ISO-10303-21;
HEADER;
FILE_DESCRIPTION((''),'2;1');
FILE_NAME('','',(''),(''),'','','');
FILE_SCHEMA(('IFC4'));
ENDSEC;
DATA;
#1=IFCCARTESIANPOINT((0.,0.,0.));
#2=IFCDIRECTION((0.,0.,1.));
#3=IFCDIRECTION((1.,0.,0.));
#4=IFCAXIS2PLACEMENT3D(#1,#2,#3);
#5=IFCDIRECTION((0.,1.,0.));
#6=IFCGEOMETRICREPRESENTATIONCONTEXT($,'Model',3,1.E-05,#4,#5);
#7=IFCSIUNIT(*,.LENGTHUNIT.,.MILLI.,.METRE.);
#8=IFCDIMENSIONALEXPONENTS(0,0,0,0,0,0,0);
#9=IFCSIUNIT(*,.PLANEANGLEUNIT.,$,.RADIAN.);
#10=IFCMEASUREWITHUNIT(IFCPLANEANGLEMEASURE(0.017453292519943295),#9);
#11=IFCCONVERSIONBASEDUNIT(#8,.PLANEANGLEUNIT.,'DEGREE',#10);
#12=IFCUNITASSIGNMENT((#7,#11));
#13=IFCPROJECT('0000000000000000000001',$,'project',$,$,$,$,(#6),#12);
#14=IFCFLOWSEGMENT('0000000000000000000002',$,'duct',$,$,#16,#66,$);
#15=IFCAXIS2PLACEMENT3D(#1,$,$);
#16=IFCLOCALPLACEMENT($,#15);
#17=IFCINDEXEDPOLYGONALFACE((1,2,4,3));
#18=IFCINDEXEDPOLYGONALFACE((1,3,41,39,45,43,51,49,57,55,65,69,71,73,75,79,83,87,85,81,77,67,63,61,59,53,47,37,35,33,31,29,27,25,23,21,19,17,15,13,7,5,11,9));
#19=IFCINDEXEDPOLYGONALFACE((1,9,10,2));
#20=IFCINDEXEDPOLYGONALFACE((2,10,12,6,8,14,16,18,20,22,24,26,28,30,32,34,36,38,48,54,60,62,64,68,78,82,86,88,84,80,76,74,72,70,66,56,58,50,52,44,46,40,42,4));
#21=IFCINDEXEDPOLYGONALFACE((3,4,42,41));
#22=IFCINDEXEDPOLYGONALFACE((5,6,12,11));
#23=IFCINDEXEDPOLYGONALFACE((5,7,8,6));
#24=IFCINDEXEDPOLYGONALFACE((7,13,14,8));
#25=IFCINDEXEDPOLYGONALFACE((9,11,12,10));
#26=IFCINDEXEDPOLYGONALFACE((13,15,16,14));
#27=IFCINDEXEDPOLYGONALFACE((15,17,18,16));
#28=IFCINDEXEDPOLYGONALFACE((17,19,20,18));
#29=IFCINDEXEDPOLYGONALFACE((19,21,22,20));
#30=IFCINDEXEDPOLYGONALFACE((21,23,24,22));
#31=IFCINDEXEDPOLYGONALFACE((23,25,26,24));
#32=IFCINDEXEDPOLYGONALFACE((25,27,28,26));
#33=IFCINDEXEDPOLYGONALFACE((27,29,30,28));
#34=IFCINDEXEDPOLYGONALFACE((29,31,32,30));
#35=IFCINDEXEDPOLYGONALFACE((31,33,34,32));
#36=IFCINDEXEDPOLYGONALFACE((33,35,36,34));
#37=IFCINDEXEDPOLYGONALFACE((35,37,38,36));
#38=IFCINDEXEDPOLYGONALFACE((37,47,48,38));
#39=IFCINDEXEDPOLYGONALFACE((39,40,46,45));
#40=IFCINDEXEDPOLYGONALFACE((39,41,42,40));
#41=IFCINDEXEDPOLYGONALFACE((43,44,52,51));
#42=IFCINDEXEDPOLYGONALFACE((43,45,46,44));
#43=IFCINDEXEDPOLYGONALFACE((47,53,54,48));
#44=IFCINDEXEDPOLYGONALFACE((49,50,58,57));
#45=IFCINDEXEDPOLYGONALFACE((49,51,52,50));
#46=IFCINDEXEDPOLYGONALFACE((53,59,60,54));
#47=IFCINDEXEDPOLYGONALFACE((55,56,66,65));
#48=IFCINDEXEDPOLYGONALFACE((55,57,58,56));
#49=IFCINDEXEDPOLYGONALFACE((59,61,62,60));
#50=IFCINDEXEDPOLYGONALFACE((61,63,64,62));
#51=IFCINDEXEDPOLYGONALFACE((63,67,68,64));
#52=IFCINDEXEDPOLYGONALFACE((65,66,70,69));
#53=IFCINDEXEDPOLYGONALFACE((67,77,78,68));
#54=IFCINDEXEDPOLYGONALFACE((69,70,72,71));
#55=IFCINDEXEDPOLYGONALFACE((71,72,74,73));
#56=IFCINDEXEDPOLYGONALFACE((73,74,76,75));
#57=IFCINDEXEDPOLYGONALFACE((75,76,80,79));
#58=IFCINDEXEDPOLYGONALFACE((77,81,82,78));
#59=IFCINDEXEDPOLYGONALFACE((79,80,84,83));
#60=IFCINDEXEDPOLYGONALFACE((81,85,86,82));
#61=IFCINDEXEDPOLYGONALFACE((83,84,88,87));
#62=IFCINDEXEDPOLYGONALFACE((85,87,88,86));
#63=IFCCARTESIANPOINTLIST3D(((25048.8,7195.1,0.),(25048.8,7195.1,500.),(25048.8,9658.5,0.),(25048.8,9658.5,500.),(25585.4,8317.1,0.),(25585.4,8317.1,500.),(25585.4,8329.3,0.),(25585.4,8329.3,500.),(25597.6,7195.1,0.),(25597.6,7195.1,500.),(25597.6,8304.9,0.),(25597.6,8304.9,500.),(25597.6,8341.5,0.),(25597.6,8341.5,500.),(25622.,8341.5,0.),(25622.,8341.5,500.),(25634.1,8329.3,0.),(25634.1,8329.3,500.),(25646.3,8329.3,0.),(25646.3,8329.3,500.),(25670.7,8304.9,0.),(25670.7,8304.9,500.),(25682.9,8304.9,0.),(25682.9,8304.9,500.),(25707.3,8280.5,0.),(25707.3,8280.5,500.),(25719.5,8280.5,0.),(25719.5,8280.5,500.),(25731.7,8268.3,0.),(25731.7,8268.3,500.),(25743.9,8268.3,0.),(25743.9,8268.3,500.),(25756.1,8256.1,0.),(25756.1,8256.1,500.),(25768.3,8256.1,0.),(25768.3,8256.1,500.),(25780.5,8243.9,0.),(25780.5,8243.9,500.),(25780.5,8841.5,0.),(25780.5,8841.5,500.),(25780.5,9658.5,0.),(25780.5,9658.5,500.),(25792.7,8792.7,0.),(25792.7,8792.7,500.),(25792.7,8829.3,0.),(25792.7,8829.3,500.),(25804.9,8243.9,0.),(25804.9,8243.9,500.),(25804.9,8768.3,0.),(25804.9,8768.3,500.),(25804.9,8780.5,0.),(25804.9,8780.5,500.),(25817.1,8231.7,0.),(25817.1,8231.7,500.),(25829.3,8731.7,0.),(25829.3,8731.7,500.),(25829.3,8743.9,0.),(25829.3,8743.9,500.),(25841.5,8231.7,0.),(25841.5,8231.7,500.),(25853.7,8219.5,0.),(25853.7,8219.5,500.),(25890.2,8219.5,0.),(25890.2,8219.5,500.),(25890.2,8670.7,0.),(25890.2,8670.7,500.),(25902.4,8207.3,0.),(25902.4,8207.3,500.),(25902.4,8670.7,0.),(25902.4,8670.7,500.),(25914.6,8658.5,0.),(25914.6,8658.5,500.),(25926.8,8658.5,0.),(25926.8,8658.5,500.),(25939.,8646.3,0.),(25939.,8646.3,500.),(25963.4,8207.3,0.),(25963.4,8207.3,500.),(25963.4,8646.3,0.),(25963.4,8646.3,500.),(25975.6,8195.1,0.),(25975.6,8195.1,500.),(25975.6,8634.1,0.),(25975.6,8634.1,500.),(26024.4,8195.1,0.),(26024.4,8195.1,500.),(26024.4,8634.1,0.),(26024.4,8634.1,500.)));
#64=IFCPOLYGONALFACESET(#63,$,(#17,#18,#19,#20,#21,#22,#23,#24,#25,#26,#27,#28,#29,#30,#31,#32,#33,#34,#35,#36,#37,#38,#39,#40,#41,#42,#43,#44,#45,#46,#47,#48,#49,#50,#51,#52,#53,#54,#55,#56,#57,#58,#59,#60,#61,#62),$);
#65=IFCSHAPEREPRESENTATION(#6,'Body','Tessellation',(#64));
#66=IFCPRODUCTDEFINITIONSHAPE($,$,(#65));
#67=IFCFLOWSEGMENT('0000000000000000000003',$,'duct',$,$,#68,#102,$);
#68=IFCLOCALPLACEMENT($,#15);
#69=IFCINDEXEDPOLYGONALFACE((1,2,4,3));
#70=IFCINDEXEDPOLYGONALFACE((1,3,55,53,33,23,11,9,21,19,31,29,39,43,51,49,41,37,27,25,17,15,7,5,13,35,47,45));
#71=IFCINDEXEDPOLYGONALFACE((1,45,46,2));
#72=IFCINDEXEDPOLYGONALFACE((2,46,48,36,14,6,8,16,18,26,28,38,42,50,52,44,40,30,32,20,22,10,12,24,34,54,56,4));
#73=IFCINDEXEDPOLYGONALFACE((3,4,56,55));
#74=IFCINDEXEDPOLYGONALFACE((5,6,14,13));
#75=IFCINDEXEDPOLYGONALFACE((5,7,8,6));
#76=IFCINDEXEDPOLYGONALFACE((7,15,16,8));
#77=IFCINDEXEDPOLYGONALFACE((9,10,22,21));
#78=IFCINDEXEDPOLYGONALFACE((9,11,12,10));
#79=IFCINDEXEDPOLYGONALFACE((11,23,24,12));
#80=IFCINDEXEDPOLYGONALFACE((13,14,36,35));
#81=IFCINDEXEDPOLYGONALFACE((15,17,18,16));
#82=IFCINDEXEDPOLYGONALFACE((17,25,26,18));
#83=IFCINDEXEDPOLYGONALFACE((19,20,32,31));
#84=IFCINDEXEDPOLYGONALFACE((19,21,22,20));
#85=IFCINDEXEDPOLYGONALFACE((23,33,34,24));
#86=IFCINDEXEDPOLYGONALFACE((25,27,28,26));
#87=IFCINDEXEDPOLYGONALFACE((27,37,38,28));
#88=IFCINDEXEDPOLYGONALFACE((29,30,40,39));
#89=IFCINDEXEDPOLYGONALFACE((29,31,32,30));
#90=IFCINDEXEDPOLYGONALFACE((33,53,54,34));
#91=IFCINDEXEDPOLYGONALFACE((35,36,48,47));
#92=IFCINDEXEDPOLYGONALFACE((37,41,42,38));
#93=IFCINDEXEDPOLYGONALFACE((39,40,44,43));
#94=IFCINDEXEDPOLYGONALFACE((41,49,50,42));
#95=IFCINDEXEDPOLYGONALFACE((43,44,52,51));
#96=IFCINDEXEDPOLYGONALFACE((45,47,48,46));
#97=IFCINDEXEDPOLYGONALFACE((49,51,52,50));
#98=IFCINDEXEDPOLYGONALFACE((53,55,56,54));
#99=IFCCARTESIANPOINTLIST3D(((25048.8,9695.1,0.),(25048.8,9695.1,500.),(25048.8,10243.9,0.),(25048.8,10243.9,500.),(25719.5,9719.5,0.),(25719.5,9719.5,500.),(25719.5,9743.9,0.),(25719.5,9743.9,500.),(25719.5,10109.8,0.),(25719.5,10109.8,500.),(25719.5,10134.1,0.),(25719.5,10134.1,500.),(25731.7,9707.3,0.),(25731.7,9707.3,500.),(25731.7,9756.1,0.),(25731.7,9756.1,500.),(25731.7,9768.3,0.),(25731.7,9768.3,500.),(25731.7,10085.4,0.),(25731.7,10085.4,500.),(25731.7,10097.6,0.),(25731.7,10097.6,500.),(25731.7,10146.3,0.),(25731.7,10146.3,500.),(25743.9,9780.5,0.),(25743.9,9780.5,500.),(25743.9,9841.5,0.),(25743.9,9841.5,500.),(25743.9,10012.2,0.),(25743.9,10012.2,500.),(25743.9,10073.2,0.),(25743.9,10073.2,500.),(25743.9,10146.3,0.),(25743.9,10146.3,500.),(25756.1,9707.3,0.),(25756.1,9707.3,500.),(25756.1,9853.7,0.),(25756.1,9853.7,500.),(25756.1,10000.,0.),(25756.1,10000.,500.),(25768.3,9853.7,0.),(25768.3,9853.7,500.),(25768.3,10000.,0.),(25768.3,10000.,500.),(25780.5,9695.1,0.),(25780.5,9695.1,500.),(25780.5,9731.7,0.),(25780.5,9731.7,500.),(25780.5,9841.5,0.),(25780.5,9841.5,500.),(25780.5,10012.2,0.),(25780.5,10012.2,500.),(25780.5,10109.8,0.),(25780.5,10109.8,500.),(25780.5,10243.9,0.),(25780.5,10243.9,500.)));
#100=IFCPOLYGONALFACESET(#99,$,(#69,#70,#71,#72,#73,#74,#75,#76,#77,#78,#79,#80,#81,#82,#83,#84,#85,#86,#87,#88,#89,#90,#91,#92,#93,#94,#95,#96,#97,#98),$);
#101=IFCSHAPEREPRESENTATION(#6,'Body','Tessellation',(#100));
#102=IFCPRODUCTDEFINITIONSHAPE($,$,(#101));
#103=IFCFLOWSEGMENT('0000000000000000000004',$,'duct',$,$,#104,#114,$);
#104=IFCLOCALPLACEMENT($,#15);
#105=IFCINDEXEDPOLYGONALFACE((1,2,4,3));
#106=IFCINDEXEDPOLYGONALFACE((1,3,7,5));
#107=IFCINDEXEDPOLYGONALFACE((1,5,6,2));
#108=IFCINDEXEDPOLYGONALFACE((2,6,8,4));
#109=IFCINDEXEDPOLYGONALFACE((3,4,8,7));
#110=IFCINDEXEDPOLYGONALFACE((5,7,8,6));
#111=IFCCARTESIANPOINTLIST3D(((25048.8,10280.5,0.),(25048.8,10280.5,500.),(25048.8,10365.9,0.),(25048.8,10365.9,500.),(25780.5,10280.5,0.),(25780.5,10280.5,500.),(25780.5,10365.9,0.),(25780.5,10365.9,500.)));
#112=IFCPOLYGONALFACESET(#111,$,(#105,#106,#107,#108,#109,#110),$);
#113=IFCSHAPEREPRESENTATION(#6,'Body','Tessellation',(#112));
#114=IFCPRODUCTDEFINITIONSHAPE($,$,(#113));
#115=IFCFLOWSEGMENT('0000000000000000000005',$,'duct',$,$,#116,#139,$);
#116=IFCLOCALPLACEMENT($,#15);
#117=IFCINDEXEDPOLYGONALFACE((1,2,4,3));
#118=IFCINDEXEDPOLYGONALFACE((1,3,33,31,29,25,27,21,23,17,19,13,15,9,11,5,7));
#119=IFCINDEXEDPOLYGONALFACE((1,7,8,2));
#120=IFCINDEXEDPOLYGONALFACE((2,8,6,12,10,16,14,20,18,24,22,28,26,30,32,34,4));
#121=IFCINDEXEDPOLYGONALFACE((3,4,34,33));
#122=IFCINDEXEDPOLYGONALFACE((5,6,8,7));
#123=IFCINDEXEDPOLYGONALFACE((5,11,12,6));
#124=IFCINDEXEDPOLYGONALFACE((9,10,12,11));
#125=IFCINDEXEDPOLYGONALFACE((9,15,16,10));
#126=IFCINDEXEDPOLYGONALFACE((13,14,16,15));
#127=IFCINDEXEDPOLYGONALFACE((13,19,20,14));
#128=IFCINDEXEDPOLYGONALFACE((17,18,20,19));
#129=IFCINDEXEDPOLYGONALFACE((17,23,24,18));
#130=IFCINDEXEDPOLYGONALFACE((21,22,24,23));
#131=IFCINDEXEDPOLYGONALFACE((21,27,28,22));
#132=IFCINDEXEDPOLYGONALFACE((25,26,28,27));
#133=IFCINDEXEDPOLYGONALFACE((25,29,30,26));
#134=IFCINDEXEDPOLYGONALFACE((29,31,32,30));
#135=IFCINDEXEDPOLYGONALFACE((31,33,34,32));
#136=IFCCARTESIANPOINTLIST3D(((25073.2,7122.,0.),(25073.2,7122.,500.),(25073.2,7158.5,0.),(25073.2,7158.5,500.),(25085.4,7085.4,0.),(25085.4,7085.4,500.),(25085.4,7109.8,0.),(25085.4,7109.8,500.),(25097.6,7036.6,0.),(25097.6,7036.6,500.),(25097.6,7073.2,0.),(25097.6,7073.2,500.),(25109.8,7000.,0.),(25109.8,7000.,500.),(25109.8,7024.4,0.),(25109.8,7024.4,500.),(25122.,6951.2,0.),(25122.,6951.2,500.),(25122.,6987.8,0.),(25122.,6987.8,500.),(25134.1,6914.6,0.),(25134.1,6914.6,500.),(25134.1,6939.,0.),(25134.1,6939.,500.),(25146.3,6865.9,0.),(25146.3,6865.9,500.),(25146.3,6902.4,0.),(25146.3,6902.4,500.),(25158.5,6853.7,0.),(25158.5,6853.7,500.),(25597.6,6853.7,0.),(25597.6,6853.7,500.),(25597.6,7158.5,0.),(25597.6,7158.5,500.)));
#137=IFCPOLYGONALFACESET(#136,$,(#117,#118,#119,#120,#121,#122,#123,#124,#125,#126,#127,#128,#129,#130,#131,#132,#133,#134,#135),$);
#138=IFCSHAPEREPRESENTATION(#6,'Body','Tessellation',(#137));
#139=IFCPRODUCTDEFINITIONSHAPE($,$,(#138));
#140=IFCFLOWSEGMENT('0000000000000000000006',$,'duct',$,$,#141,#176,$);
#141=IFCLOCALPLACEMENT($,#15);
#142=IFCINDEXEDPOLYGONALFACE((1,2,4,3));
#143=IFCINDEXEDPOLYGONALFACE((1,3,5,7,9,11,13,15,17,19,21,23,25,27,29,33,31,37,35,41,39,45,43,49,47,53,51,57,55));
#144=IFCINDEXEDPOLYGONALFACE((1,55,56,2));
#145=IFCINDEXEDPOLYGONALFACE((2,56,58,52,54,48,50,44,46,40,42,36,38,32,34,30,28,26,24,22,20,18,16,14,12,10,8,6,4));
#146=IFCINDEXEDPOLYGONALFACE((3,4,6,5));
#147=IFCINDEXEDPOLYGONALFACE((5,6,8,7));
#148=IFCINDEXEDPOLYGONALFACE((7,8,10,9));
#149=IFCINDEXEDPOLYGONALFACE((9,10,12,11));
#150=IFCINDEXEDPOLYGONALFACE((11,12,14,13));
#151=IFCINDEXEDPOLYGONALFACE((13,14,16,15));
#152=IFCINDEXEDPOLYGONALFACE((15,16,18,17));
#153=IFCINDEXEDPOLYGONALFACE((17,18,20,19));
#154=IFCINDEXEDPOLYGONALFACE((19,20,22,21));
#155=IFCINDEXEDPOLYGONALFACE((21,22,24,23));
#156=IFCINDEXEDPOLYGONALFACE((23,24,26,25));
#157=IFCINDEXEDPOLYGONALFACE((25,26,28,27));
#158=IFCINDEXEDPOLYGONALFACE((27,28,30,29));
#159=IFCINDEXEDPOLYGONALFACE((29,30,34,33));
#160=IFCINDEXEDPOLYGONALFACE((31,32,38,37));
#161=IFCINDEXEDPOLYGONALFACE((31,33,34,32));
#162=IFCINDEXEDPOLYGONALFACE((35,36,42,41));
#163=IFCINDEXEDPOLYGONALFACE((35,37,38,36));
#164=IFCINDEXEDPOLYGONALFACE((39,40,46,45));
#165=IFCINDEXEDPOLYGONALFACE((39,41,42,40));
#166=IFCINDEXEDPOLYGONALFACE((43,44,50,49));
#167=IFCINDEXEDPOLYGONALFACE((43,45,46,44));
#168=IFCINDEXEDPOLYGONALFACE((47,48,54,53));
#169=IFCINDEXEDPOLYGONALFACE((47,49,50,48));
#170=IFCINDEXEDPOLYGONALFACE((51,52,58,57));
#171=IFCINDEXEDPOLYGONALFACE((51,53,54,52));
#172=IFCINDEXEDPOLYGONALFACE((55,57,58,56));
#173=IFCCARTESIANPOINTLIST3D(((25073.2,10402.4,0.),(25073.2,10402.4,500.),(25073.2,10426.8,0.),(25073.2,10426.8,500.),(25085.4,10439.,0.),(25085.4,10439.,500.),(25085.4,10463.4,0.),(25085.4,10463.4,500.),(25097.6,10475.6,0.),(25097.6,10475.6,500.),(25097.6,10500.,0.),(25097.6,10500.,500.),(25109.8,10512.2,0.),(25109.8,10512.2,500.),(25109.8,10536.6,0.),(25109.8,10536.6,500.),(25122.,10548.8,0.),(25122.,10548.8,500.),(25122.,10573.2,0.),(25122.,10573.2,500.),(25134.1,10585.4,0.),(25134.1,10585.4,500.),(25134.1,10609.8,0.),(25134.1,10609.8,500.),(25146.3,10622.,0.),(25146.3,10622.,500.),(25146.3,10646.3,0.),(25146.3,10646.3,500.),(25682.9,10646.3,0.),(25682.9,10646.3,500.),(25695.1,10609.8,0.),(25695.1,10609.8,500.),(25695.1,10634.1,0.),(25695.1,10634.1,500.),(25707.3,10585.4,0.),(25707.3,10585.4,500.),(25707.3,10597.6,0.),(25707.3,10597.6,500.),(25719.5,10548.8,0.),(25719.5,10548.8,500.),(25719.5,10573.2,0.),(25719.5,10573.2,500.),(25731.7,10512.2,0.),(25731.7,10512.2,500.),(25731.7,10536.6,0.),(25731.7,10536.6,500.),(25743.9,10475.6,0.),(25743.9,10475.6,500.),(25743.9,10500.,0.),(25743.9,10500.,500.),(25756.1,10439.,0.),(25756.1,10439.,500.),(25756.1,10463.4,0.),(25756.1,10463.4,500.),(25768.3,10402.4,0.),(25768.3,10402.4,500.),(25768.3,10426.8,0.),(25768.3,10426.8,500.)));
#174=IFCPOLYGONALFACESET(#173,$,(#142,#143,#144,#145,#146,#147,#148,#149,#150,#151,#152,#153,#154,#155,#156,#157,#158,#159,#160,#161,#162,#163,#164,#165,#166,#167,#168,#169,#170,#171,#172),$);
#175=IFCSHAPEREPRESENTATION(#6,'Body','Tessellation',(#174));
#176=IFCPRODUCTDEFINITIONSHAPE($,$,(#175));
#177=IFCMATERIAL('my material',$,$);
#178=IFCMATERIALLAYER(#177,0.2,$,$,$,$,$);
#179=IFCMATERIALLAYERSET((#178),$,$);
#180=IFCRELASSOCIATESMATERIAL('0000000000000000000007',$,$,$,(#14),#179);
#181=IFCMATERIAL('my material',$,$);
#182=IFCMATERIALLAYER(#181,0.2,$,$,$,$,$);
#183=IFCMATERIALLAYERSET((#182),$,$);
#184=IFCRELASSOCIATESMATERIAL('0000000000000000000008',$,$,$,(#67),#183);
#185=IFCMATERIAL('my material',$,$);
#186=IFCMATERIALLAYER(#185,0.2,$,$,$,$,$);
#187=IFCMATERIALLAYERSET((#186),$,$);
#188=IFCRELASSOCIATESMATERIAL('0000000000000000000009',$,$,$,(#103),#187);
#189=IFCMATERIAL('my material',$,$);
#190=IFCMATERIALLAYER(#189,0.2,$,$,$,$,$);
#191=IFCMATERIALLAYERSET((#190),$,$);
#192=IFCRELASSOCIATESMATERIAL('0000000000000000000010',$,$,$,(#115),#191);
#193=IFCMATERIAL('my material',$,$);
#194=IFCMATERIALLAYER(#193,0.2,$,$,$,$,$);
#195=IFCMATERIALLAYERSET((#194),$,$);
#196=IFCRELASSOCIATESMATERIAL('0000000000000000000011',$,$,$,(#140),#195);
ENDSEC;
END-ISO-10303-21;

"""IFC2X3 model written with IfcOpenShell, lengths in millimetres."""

from ifc_helpers import new_model, entity, si_unit, converted_unit, direction, origin_with_axes, place, context, project, polyline, outline, extrude, material, layer, layer_set, layer_usage, element, save


model = new_model("IFC2X3")

# Units and contexts
model_context = context("Model", 3, precision=1e-05, world=origin_with_axes(), true_north=direction((0.0, 1.0, 0.0)))
ifc_project = project(units=[si_unit("LENGTHUNIT", "METRE", prefix="MILLI"), converted_unit("PLANEANGLEUNIT", "DEGREE", entity("IfcPlaneAngleMeasure", 0.017453292519943295), si_unit("PLANEANGLEUNIT", "RADIAN"), dimensions=[0, 0, 0, 0, 0, 0, 0])], contexts=[model_context])

# Flow segments
ifc_material_1 = material(Name="my material")
ifc_layer_1 = layer(ifc_material_1, 0.2)
ifc_layer_set_1 = layer_set([ifc_layer_1])
ifc_layer_usage_1 = layer_usage(ifc_layer_set_1, "AXIS2", "POSITIVE", -0.1)
flow_segment_1_placement = place(None, origin_with_axes())
element("IfcFlowSegment", 1, at=flow_segment_1_placement, material=ifc_layer_usage_1, Name="duct", context=model_context, shape_type="SweptSolid", body=[
    extrude(outline(polyline([(25048.8, 7195.1), (25597.6, 7195.1), (25597.6, 8304.9), (25585.4, 8317.1), (25585.4, 8329.3), (25597.6, 8341.5), (25622.0, 8341.5), (25634.1, 8329.3), (25646.3, 8329.3), (25670.7, 8304.9), (25682.9, 8304.9), (25707.3, 8280.5), (25719.5, 8280.5), (25731.7, 8268.3), (25743.9, 8268.3), (25756.1, 8256.1), (25768.3, 8256.1), (25780.5, 8243.9), (25804.9, 8243.9), (25817.1, 8231.7), (25841.5, 8231.7), (25853.7, 8219.5), (25890.2, 8219.5), (25902.4, 8207.3), (25963.4, 8207.3), (25975.6, 8195.1), (26024.4, 8195.1), (26024.4, 8634.1), (25975.6, 8634.1), (25963.4, 8646.3), (25939.0, 8646.3), (25926.8, 8658.5), (25914.6, 8658.5), (25902.4, 8670.7), (25890.2, 8670.7), (25829.3, 8731.7), (25829.3, 8743.9), (25804.9, 8768.3), (25804.9, 8780.5), (25792.7, 8792.7), (25792.7, 8829.3), (25780.5, 8841.5), (25780.5, 9658.5), (25048.8, 9658.5), (25048.8, 7195.1)])), origin_with_axes(), (0.0, 0.0, 1.0), 500.0),
])
ifc_material_2 = material(Name="my material")
ifc_layer_2 = layer(ifc_material_2, 0.2)
ifc_layer_set_2 = layer_set([ifc_layer_2])
ifc_layer_usage_2 = layer_usage(ifc_layer_set_2, "AXIS2", "POSITIVE", -0.1)
flow_segment_2_placement = place(None, origin_with_axes())
element("IfcFlowSegment", 2, at=flow_segment_2_placement, material=ifc_layer_usage_2, Name="duct", context=model_context, shape_type="SweptSolid", body=[
    extrude(outline(polyline([(25048.8, 9695.1), (25780.5, 9695.1), (25780.5, 9743.9), (25780.5, 9731.7), (25756.1, 9707.3), (25731.7, 9707.3), (25719.5, 9719.5), (25719.5, 9743.9), (25731.7, 9756.1), (25731.7, 9768.3), (25743.9, 9780.5), (25743.9, 9841.5), (25756.1, 9853.7), (25768.3, 9853.7), (25780.5, 9841.5), (25780.5, 9792.7), (25780.5, 10061.0), (25780.5, 10012.2), (25768.3, 10000.0), (25756.1, 10000.0), (25743.9, 10012.2), (25743.9, 10073.2), (25731.7, 10085.4), (25731.7, 10097.6), (25719.5, 10109.8), (25719.5, 10134.1), (25731.7, 10146.3), (25743.9, 10146.3), (25780.5, 10109.8), (25780.5, 10097.6), (25780.5, 10243.9), (25048.8, 10243.9), (25048.8, 9695.1)])), origin_with_axes(), (0.0, 0.0, 1.0), 500.0),
])
ifc_material_3 = material(Name="my material")
ifc_layer_3 = layer(ifc_material_3, 0.2)
ifc_layer_set_3 = layer_set([ifc_layer_3])
ifc_layer_usage_3 = layer_usage(ifc_layer_set_3, "AXIS2", "POSITIVE", -0.1)
flow_segment_3_placement = place(None, origin_with_axes())
element("IfcFlowSegment", 3, at=flow_segment_3_placement, material=ifc_layer_usage_3, Name="duct", context=model_context, shape_type="SweptSolid", body=[
    extrude(outline(polyline([(25048.8, 10280.5), (25780.5, 10280.5), (25780.5, 10365.9), (25048.8, 10365.9), (25048.8, 10280.5)])), origin_with_axes(), (0.0, 0.0, 1.0), 500.0),
])
ifc_material_4 = material(Name="my material")
ifc_layer_4 = layer(ifc_material_4, 0.2)
ifc_layer_set_4 = layer_set([ifc_layer_4])
ifc_layer_usage_4 = layer_usage(ifc_layer_set_4, "AXIS2", "POSITIVE", -0.1)
flow_segment_4_placement = place(None, origin_with_axes())
element("IfcFlowSegment", 4, at=flow_segment_4_placement, material=ifc_layer_usage_4, Name="duct", context=model_context, shape_type="SweptSolid", body=[
    extrude(outline(polyline([(25073.2, 7122.0), (25085.4, 7109.8), (25085.4, 7085.4), (25097.6, 7073.2), (25097.6, 7036.6), (25109.8, 7024.4), (25109.8, 7000.0), (25122.0, 6987.8), (25122.0, 6951.2), (25134.1, 6939.0), (25134.1, 6914.6), (25146.3, 6902.4), (25146.3, 6865.9), (25158.5, 6853.7), (25597.6, 6853.7), (25597.6, 7158.5), (25073.2, 7158.5), (25073.2, 7122.0)])), origin_with_axes(), (0.0, 0.0, 1.0), 500.0),
])
ifc_material_5 = material(Name="my material")
ifc_layer_5 = layer(ifc_material_5, 0.2)
ifc_layer_set_5 = layer_set([ifc_layer_5])
ifc_layer_usage_5 = layer_usage(ifc_layer_set_5, "AXIS2", "POSITIVE", -0.1)
flow_segment_5_placement = place(None, origin_with_axes())
element("IfcFlowSegment", 5, at=flow_segment_5_placement, material=ifc_layer_usage_5, Name="duct", context=model_context, shape_type="SweptSolid", body=[
    extrude(outline(polyline([(25073.2, 10402.4), (25768.3, 10402.4), (25768.3, 10426.8), (25756.1, 10439.0), (25756.1, 10463.4), (25743.9, 10475.6), (25743.9, 10500.0), (25731.7, 10512.2), (25731.7, 10536.6), (25719.5, 10548.8), (25719.5, 10573.2), (25707.3, 10585.4), (25707.3, 10597.6), (25695.1, 10609.8), (25695.1, 10634.1), (25682.9, 10646.3), (25146.3, 10646.3), (25146.3, 10622.0), (25134.1, 10609.8), (25134.1, 10585.4), (25122.0, 10573.2), (25122.0, 10548.8), (25109.8, 10536.6), (25109.8, 10512.2), (25097.6, 10500.0), (25097.6, 10475.6), (25085.4, 10463.4), (25085.4, 10439.0), (25073.2, 10426.8), (25073.2, 10402.4)])), origin_with_axes(), (0.0, 0.0, 1.0), 500.0),
])

save(model, "model.ifc")
